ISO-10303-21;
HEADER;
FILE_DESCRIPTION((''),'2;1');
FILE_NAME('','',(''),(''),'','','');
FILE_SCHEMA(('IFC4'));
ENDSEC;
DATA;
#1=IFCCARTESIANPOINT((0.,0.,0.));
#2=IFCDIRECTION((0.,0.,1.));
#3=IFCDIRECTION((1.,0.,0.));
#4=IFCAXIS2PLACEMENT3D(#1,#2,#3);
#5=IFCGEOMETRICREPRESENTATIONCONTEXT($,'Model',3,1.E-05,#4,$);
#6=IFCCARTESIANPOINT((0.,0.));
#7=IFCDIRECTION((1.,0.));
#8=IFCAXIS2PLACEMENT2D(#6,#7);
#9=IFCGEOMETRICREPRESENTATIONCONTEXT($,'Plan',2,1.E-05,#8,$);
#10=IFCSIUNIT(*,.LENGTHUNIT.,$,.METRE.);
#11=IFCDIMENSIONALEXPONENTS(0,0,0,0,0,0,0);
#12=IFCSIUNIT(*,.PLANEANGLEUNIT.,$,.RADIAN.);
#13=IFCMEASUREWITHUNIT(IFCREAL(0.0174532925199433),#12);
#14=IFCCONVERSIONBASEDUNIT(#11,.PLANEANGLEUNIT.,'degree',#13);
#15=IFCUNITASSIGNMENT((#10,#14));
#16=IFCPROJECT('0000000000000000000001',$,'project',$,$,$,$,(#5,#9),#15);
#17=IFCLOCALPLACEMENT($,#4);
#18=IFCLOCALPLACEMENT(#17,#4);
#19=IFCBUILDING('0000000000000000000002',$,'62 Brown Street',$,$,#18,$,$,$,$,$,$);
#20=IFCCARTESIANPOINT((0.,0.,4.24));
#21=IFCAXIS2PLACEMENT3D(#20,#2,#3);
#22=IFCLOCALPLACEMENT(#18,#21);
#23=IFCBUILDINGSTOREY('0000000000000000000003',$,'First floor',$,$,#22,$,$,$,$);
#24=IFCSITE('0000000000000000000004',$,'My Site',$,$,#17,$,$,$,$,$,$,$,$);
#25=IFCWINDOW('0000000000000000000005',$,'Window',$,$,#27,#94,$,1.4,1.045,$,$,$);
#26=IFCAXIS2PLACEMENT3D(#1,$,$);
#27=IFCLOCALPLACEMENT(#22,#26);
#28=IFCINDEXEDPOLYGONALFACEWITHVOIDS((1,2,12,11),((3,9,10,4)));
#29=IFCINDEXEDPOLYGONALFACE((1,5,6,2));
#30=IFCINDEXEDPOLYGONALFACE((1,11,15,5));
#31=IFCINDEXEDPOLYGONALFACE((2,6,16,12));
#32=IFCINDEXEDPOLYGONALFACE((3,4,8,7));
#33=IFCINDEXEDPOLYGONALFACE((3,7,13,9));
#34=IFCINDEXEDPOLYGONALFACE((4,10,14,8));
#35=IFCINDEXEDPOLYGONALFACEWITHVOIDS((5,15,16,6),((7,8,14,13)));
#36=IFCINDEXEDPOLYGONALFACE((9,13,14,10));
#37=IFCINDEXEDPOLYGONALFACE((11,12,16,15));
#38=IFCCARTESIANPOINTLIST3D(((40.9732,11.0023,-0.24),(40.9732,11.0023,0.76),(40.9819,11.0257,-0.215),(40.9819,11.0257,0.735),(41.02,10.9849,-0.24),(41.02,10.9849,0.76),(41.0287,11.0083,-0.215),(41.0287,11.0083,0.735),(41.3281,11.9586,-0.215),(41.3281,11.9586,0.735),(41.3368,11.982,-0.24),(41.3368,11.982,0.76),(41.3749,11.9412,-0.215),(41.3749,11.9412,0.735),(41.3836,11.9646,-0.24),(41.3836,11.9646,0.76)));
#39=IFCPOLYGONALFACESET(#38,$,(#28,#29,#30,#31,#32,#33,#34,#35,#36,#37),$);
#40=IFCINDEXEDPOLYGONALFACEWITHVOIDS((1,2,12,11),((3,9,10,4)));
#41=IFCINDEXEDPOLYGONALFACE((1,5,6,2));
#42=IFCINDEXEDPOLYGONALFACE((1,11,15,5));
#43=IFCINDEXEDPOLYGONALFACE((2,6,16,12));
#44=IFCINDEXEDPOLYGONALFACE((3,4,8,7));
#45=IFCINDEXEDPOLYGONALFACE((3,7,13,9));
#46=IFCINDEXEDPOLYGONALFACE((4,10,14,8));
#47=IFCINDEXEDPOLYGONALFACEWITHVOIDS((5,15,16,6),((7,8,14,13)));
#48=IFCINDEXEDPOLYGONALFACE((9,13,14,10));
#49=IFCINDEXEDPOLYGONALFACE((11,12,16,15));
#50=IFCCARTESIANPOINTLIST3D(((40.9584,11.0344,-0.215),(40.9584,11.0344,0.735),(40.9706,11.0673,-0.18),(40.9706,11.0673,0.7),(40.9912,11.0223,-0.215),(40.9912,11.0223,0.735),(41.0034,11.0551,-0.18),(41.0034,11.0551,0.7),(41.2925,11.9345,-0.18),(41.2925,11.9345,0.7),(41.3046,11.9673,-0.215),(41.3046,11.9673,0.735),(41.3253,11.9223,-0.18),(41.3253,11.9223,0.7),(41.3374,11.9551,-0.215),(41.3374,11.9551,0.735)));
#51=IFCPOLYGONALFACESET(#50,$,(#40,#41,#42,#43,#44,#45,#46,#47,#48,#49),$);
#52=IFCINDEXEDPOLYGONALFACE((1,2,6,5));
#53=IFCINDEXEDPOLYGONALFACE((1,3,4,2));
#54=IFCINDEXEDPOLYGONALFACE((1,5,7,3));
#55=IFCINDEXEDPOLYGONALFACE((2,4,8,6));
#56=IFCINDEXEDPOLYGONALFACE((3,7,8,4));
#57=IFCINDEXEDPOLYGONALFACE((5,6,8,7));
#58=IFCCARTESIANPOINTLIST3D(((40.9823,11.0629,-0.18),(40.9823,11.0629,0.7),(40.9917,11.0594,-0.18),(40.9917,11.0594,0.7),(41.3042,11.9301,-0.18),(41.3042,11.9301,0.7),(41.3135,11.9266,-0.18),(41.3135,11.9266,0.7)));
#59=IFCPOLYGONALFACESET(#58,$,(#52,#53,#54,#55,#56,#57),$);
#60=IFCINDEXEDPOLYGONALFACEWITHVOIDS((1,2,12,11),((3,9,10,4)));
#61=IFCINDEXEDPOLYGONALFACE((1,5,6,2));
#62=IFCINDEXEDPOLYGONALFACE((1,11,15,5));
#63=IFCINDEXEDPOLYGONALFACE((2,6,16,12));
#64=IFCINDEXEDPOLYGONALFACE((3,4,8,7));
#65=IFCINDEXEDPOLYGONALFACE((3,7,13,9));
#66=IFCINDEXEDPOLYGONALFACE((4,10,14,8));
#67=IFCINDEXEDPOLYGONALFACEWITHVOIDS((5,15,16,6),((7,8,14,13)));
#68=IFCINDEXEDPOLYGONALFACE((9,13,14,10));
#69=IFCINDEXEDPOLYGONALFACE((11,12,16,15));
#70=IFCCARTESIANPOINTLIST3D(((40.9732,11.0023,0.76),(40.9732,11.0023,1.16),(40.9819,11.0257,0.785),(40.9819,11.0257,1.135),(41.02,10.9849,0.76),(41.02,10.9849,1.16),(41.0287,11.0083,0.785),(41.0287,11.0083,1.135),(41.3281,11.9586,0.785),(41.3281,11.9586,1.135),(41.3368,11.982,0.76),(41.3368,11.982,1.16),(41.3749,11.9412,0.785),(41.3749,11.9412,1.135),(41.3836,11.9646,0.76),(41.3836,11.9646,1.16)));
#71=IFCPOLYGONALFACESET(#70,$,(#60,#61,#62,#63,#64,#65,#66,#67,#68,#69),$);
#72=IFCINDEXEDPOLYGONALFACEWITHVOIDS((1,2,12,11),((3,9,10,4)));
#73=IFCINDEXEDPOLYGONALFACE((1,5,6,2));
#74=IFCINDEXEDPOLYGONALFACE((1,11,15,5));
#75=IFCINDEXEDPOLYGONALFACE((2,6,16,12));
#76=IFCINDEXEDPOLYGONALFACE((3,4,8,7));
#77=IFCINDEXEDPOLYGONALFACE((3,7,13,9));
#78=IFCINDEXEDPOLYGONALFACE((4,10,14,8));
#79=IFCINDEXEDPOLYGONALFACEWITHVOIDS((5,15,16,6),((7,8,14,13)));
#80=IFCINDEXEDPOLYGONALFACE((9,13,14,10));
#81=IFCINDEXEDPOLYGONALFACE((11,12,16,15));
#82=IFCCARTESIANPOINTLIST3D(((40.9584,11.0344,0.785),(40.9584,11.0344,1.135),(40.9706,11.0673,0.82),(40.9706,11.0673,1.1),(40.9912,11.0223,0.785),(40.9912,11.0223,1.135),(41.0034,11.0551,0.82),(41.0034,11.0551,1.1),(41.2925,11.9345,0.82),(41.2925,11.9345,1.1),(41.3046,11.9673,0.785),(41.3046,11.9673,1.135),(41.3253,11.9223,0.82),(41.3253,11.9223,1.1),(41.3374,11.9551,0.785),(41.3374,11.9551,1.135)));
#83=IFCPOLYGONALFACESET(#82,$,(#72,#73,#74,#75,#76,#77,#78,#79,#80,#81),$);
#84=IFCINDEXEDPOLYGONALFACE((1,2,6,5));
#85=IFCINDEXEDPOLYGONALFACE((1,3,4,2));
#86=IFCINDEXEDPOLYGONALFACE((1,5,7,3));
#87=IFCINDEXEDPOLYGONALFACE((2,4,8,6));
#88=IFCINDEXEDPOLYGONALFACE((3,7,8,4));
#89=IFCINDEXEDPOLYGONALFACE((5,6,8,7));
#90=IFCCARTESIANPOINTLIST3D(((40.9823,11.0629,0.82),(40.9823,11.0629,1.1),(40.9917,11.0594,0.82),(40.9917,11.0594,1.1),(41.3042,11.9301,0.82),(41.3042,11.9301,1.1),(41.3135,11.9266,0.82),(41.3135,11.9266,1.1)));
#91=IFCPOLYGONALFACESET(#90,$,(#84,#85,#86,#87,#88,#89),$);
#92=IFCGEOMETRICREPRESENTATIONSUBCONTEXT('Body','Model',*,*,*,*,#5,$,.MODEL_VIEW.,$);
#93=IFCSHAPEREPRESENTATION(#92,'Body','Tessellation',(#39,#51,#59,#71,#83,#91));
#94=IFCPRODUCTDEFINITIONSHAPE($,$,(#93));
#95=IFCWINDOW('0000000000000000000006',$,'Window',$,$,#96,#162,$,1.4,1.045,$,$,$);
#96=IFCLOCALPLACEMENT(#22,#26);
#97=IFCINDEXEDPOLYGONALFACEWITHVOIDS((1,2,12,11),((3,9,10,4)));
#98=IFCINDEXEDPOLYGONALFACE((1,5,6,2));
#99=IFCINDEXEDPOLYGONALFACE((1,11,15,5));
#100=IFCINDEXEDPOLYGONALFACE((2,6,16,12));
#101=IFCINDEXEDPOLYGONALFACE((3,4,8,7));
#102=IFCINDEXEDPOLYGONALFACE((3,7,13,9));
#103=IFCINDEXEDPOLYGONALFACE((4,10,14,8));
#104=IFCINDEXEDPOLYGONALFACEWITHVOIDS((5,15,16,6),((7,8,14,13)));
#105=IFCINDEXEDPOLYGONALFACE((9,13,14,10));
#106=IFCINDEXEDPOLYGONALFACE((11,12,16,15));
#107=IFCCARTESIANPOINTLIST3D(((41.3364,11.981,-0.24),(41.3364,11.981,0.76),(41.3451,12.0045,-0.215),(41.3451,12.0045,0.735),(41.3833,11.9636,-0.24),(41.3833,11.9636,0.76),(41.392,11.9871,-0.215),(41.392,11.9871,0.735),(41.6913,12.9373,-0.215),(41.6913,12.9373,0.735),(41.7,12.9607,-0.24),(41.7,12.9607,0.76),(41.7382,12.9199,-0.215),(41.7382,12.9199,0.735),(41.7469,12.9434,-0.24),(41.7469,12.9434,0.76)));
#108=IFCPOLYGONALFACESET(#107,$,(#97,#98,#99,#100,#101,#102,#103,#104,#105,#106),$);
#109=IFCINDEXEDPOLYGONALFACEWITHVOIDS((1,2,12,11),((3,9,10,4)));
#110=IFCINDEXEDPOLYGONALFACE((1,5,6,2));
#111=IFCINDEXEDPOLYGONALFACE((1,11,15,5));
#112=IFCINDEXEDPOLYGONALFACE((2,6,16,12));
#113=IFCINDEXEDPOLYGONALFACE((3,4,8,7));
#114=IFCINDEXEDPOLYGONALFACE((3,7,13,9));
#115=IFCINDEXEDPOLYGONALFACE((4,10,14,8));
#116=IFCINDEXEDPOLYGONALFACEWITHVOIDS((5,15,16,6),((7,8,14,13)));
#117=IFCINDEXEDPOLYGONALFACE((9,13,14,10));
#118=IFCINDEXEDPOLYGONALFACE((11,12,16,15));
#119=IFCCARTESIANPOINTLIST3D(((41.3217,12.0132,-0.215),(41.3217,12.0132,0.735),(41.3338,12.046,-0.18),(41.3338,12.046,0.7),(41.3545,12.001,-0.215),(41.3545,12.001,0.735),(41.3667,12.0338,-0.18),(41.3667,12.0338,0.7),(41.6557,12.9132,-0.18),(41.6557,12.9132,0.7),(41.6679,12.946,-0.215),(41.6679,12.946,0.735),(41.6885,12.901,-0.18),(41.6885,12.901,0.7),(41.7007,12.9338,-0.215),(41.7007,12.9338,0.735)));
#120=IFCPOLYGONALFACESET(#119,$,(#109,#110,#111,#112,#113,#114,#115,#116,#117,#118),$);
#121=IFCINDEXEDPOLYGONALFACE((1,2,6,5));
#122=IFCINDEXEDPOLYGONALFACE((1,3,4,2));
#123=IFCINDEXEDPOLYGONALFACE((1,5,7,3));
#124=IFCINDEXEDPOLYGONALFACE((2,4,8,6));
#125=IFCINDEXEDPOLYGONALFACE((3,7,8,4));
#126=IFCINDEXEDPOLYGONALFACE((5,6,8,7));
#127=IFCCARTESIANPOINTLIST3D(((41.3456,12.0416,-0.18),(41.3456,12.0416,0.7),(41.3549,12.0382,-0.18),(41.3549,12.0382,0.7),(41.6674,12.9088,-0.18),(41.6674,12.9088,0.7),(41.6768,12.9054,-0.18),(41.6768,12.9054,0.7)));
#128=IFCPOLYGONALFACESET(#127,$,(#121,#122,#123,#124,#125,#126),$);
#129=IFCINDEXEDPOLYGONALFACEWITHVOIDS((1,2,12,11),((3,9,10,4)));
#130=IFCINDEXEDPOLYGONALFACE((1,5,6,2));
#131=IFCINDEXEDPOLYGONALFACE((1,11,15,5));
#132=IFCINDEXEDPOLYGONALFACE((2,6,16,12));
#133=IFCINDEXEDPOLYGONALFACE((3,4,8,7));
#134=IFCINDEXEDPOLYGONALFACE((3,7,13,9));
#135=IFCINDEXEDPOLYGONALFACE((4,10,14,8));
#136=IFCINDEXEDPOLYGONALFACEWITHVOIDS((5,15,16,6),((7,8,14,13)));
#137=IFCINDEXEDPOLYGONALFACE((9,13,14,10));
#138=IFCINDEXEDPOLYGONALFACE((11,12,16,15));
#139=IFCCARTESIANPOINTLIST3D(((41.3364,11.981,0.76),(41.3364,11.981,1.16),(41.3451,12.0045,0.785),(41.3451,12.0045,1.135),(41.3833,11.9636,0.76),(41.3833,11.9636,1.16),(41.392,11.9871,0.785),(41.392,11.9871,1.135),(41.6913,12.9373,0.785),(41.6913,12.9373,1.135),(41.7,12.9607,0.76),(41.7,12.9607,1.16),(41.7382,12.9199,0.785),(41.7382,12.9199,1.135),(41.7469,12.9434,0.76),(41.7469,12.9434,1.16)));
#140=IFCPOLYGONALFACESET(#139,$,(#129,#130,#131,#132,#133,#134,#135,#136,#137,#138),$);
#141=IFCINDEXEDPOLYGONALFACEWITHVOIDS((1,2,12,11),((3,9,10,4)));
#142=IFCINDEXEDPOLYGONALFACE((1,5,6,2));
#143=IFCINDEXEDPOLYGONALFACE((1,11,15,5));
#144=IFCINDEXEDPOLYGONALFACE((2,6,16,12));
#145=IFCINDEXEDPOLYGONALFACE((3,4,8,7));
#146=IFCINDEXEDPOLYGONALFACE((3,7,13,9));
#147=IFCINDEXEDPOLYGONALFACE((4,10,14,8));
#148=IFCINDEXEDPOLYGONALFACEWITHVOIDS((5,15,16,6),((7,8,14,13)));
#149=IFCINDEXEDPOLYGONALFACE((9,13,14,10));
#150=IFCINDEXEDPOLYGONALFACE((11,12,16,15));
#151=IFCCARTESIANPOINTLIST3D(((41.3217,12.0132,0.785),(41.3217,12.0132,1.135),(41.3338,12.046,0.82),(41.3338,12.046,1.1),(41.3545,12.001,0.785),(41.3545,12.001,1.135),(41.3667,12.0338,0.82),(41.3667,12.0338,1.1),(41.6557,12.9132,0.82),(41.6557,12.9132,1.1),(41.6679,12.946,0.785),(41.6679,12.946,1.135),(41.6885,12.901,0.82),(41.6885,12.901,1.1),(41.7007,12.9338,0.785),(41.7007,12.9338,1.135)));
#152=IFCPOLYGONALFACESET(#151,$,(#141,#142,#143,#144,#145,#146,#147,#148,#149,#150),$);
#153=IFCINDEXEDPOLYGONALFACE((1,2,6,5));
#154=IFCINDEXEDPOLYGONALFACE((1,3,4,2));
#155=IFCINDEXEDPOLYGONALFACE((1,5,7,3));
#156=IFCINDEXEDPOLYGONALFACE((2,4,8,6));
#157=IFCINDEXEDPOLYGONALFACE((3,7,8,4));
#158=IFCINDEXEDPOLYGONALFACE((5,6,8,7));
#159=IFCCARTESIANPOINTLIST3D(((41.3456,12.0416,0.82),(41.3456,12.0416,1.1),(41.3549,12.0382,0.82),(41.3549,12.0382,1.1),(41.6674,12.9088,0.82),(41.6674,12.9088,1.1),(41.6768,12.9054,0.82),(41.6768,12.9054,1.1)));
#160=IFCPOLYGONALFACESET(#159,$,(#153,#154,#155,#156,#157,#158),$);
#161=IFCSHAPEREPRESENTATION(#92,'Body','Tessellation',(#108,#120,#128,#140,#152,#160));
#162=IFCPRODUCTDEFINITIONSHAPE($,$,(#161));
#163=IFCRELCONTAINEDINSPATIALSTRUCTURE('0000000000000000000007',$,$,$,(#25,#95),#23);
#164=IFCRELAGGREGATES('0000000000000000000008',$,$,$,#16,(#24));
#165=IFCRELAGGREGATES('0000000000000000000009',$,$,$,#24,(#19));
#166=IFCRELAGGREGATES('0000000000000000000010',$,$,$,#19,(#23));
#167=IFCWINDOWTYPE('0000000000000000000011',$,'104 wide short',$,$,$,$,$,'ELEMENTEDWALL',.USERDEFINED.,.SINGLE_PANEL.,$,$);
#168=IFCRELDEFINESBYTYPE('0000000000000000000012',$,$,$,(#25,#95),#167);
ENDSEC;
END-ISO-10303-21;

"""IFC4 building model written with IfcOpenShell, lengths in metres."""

from ifc_helpers import new_model, entity, si_unit, converted_unit, frame, origin_with_axes, origin_2d_with_axis, place, context, subcontext, project, spatial, line, indexed_curve, outline, extrude, shape, source, transform, mapped, type_object, type_shapes, element, save


model = new_model("IFC4")

# Units and contexts
model_context = context("Model", 3, precision=1e-05, world=origin_with_axes())
plan_context = context("Plan", 2, precision=1e-05, world=origin_2d_with_axis())
body_context_1 = subcontext(model_context, "Body", "Model", "MODEL_VIEW")
body_context_2 = subcontext(plan_context, "Body", "Plan", "PLAN_VIEW")
ifc_project = project(units=[si_unit("LENGTHUNIT", "METRE"), converted_unit("PLANEANGLEUNIT", "degree", entity("IfcReal", 0.0174532925199433), si_unit("PLANEANGLEUNIT", "RADIAN"), dimensions=[0, 0, 0, 0, 0, 0, 0])], contexts=[model_context, plan_context])

# Site, building, storey
site_placement = place(None, origin_with_axes())
site = spatial("IfcSite", under=ifc_project, at=site_placement, Name="My Site")
building_placement = place(site_placement, origin_with_axes())
building = spatial("IfcBuilding", under=site, at=building_placement, Name="62 Brown Street")
storey_placement = place(building_placement, frame((0.0, 0.0, 4.24), z_axis=(0.0, 0.0, 1.0), x_axis=(1.0, 0.0, 0.0)))
storey = spatial("IfcBuildingStorey", under=building, at=storey_placement, Name="First floor")

# Shared definitions
window_type = type_object("IfcWindowType", Name="104 wide short", ElementType="ELEMENTEDWALL", PartitioningType="SINGLE_PANEL", PredefinedType="USERDEFINED")
shared_shape_1 = source(origin_with_axes(), body_context_1, "Body", "SweptSolid", [
    extrude(outline(indexed_curve([(0.0, 0.0), (1.045, 0.0), (1.045, 1.0), (0.0, 1.0)], segments=[line(1, 2, 3, 4, 1)]), holes=[indexed_curve([(0.025, 0.025), (1.02, 0.025), (1.02, 0.975), (0.025, 0.975)], segments=[line(1, 2, 3, 4, 1)])]), frame((0.0, 0.15, 0.0), z_axis=(0.0, -1.0, 0.0), x_axis=(1.0, 0.0, 0.0)), (0.0, 0.0, -1.0), 0.05),
    extrude(outline(indexed_curve([(0.0, 0.0), (0.995, 0.0), (0.995, 0.95), (0.0, 0.95)], segments=[line(1, 2, 3, 4, 1)]), holes=[indexed_curve([(0.035, 0.035), (0.96, 0.035), (0.96, 0.915), (0.035, 0.915)], segments=[line(1, 2, 3, 4, 1)])]), frame((0.025, 0.19, 0.025), z_axis=(0.0, -1.0, 0.0), x_axis=(1.0, 0.0, 0.0)), (0.0, 0.0, -1.0), 0.035),
    extrude(outline(indexed_curve([(0.035, 0.035), (0.96, 0.035), (0.96, 0.915), (0.035, 0.915)], segments=[line(1, 2, 3, 4, 1)])), frame((0.025, 0.2025, 0.025), z_axis=(0.0, -1.0, 0.0), x_axis=(1.0, 0.0, 0.0)), (0.0, 0.0, -1.0), 0.01),
    extrude(outline(indexed_curve([(0.0, 0.0), (1.045, 0.0), (1.045, 0.4), (0.0, 0.4)], segments=[line(1, 2, 3, 4, 1)]), holes=[indexed_curve([(0.025, 0.025), (1.02, 0.025), (1.02, 0.375), (0.025, 0.375)], segments=[line(1, 2, 3, 4, 1)])]), frame((0.0, 0.15, 1.0), z_axis=(0.0, -1.0, 0.0), x_axis=(1.0, 0.0, 0.0)), (0.0, 0.0, -1.0), 0.05),
    extrude(outline(indexed_curve([(0.0, 0.0), (0.995, 0.0), (0.995, 0.35), (0.0, 0.35)], segments=[line(1, 2, 3, 4, 1)]), holes=[indexed_curve([(0.035, 0.035), (0.96, 0.035), (0.96, 0.315), (0.035, 0.315)], segments=[line(1, 2, 3, 4, 1)])]), frame((0.025, 0.19, 1.025), z_axis=(0.0, -1.0, 0.0), x_axis=(1.0, 0.0, 0.0)), (0.0, 0.0, -1.0), 0.035),
    extrude(outline(indexed_curve([(0.035, 0.035), (0.96, 0.035), (0.96, 0.315), (0.035, 0.315)], segments=[line(1, 2, 3, 4, 1)])), frame((0.025, 0.2025, 1.025), z_axis=(0.0, -1.0, 0.0), x_axis=(1.0, 0.0, 0.0)), (0.0, 0.0, -1.0), 0.01),
])
shared_shape_2 = source(origin_with_axes(), body_context_2, "Body", "Curve2D", [
    entity("IfcIndexedPolyCurve", entity("IfcCartesianPointList2D", [[0.025, 0.15], [1.02, 0.15]])),
    entity("IfcIndexedPolyCurve", entity("IfcCartesianPointList2D", [[0.0, 0.2], [0.025, 0.2], [0.025, 0.15], [0.0, 0.15]]), [entity("IfcLineIndex", [1, 2, 3, 4, 1])]),
    entity("IfcIndexedPolyCurve", entity("IfcCartesianPointList2D", [[1.045, 0.2], [1.02, 0.2], [1.02, 0.15], [1.045, 0.15]]), [entity("IfcLineIndex", [1, 2, 3, 4, 1])]),
    entity("IfcIndexedPolyCurve", entity("IfcCartesianPointList2D", [[0.025, 0.19], [0.06, 0.19], [0.06, 0.225], [0.025, 0.225]]), [entity("IfcLineIndex", [1, 2, 3, 4, 1])]),
    entity("IfcIndexedPolyCurve", entity("IfcCartesianPointList2D", [[1.02, 0.19], [0.985, 0.19], [0.985, 0.225], [1.02, 0.225]]), [entity("IfcLineIndex", [1, 2, 3, 4, 1])]),
    entity("IfcIndexedPolyCurve", entity("IfcCartesianPointList2D", [[0.06, 0.19], [0.985, 0.19]])),
    entity("IfcIndexedPolyCurve", entity("IfcCartesianPointList2D", [[0.06, 0.225], [0.985, 0.225]])),
    entity("IfcIndexedPolyCurve", entity("IfcCartesianPointList2D", [[0.06, 0.2075], [0.985, 0.2075]])),
])
type_shapes(window_type, [shared_shape_1, shared_shape_2])

# Windows
for number, where, z_axis, x_axis, name in (
    (1, (41.1607, 10.9327, -0.24), (0.0, 0.0, 1.0), (0.347944, 0.937515, 0.0), "Window"),
    (2, (41.5239, 11.9115, -0.24), (0.0, 0.0, 1.0), (0.347944, 0.937515, 0.0), "Window"),
):
    element("IfcWindow", number, at=place(storey_placement, frame(where, z_axis=z_axis, x_axis=x_axis)), inside=storey, type_object=window_type, Name=name, OverallHeight=1.4, OverallWidth=1.045, shapes=[
        shape(body_context_1, "Body", "MappedRepresentation", [mapped(shared_shape_1, transform((0.0, 0.0, 0.0), x_axis=(1.0, 0.0, 0.0), y_axis=(0.0, 1.0, 0.0), z_axis=(0.0, 0.0, 1.0), scale=1.0))]),
        shape(body_context_2, "Body", "MappedRepresentation", [mapped(shared_shape_2, transform((0.0, 0.0, 0.0), x_axis=(1.0, 0.0, 0.0), y_axis=(0.0, 1.0, 0.0), z_axis=(0.0, 0.0, 1.0), scale=1.0))]),
    ])

save(model, "model.ifc")
